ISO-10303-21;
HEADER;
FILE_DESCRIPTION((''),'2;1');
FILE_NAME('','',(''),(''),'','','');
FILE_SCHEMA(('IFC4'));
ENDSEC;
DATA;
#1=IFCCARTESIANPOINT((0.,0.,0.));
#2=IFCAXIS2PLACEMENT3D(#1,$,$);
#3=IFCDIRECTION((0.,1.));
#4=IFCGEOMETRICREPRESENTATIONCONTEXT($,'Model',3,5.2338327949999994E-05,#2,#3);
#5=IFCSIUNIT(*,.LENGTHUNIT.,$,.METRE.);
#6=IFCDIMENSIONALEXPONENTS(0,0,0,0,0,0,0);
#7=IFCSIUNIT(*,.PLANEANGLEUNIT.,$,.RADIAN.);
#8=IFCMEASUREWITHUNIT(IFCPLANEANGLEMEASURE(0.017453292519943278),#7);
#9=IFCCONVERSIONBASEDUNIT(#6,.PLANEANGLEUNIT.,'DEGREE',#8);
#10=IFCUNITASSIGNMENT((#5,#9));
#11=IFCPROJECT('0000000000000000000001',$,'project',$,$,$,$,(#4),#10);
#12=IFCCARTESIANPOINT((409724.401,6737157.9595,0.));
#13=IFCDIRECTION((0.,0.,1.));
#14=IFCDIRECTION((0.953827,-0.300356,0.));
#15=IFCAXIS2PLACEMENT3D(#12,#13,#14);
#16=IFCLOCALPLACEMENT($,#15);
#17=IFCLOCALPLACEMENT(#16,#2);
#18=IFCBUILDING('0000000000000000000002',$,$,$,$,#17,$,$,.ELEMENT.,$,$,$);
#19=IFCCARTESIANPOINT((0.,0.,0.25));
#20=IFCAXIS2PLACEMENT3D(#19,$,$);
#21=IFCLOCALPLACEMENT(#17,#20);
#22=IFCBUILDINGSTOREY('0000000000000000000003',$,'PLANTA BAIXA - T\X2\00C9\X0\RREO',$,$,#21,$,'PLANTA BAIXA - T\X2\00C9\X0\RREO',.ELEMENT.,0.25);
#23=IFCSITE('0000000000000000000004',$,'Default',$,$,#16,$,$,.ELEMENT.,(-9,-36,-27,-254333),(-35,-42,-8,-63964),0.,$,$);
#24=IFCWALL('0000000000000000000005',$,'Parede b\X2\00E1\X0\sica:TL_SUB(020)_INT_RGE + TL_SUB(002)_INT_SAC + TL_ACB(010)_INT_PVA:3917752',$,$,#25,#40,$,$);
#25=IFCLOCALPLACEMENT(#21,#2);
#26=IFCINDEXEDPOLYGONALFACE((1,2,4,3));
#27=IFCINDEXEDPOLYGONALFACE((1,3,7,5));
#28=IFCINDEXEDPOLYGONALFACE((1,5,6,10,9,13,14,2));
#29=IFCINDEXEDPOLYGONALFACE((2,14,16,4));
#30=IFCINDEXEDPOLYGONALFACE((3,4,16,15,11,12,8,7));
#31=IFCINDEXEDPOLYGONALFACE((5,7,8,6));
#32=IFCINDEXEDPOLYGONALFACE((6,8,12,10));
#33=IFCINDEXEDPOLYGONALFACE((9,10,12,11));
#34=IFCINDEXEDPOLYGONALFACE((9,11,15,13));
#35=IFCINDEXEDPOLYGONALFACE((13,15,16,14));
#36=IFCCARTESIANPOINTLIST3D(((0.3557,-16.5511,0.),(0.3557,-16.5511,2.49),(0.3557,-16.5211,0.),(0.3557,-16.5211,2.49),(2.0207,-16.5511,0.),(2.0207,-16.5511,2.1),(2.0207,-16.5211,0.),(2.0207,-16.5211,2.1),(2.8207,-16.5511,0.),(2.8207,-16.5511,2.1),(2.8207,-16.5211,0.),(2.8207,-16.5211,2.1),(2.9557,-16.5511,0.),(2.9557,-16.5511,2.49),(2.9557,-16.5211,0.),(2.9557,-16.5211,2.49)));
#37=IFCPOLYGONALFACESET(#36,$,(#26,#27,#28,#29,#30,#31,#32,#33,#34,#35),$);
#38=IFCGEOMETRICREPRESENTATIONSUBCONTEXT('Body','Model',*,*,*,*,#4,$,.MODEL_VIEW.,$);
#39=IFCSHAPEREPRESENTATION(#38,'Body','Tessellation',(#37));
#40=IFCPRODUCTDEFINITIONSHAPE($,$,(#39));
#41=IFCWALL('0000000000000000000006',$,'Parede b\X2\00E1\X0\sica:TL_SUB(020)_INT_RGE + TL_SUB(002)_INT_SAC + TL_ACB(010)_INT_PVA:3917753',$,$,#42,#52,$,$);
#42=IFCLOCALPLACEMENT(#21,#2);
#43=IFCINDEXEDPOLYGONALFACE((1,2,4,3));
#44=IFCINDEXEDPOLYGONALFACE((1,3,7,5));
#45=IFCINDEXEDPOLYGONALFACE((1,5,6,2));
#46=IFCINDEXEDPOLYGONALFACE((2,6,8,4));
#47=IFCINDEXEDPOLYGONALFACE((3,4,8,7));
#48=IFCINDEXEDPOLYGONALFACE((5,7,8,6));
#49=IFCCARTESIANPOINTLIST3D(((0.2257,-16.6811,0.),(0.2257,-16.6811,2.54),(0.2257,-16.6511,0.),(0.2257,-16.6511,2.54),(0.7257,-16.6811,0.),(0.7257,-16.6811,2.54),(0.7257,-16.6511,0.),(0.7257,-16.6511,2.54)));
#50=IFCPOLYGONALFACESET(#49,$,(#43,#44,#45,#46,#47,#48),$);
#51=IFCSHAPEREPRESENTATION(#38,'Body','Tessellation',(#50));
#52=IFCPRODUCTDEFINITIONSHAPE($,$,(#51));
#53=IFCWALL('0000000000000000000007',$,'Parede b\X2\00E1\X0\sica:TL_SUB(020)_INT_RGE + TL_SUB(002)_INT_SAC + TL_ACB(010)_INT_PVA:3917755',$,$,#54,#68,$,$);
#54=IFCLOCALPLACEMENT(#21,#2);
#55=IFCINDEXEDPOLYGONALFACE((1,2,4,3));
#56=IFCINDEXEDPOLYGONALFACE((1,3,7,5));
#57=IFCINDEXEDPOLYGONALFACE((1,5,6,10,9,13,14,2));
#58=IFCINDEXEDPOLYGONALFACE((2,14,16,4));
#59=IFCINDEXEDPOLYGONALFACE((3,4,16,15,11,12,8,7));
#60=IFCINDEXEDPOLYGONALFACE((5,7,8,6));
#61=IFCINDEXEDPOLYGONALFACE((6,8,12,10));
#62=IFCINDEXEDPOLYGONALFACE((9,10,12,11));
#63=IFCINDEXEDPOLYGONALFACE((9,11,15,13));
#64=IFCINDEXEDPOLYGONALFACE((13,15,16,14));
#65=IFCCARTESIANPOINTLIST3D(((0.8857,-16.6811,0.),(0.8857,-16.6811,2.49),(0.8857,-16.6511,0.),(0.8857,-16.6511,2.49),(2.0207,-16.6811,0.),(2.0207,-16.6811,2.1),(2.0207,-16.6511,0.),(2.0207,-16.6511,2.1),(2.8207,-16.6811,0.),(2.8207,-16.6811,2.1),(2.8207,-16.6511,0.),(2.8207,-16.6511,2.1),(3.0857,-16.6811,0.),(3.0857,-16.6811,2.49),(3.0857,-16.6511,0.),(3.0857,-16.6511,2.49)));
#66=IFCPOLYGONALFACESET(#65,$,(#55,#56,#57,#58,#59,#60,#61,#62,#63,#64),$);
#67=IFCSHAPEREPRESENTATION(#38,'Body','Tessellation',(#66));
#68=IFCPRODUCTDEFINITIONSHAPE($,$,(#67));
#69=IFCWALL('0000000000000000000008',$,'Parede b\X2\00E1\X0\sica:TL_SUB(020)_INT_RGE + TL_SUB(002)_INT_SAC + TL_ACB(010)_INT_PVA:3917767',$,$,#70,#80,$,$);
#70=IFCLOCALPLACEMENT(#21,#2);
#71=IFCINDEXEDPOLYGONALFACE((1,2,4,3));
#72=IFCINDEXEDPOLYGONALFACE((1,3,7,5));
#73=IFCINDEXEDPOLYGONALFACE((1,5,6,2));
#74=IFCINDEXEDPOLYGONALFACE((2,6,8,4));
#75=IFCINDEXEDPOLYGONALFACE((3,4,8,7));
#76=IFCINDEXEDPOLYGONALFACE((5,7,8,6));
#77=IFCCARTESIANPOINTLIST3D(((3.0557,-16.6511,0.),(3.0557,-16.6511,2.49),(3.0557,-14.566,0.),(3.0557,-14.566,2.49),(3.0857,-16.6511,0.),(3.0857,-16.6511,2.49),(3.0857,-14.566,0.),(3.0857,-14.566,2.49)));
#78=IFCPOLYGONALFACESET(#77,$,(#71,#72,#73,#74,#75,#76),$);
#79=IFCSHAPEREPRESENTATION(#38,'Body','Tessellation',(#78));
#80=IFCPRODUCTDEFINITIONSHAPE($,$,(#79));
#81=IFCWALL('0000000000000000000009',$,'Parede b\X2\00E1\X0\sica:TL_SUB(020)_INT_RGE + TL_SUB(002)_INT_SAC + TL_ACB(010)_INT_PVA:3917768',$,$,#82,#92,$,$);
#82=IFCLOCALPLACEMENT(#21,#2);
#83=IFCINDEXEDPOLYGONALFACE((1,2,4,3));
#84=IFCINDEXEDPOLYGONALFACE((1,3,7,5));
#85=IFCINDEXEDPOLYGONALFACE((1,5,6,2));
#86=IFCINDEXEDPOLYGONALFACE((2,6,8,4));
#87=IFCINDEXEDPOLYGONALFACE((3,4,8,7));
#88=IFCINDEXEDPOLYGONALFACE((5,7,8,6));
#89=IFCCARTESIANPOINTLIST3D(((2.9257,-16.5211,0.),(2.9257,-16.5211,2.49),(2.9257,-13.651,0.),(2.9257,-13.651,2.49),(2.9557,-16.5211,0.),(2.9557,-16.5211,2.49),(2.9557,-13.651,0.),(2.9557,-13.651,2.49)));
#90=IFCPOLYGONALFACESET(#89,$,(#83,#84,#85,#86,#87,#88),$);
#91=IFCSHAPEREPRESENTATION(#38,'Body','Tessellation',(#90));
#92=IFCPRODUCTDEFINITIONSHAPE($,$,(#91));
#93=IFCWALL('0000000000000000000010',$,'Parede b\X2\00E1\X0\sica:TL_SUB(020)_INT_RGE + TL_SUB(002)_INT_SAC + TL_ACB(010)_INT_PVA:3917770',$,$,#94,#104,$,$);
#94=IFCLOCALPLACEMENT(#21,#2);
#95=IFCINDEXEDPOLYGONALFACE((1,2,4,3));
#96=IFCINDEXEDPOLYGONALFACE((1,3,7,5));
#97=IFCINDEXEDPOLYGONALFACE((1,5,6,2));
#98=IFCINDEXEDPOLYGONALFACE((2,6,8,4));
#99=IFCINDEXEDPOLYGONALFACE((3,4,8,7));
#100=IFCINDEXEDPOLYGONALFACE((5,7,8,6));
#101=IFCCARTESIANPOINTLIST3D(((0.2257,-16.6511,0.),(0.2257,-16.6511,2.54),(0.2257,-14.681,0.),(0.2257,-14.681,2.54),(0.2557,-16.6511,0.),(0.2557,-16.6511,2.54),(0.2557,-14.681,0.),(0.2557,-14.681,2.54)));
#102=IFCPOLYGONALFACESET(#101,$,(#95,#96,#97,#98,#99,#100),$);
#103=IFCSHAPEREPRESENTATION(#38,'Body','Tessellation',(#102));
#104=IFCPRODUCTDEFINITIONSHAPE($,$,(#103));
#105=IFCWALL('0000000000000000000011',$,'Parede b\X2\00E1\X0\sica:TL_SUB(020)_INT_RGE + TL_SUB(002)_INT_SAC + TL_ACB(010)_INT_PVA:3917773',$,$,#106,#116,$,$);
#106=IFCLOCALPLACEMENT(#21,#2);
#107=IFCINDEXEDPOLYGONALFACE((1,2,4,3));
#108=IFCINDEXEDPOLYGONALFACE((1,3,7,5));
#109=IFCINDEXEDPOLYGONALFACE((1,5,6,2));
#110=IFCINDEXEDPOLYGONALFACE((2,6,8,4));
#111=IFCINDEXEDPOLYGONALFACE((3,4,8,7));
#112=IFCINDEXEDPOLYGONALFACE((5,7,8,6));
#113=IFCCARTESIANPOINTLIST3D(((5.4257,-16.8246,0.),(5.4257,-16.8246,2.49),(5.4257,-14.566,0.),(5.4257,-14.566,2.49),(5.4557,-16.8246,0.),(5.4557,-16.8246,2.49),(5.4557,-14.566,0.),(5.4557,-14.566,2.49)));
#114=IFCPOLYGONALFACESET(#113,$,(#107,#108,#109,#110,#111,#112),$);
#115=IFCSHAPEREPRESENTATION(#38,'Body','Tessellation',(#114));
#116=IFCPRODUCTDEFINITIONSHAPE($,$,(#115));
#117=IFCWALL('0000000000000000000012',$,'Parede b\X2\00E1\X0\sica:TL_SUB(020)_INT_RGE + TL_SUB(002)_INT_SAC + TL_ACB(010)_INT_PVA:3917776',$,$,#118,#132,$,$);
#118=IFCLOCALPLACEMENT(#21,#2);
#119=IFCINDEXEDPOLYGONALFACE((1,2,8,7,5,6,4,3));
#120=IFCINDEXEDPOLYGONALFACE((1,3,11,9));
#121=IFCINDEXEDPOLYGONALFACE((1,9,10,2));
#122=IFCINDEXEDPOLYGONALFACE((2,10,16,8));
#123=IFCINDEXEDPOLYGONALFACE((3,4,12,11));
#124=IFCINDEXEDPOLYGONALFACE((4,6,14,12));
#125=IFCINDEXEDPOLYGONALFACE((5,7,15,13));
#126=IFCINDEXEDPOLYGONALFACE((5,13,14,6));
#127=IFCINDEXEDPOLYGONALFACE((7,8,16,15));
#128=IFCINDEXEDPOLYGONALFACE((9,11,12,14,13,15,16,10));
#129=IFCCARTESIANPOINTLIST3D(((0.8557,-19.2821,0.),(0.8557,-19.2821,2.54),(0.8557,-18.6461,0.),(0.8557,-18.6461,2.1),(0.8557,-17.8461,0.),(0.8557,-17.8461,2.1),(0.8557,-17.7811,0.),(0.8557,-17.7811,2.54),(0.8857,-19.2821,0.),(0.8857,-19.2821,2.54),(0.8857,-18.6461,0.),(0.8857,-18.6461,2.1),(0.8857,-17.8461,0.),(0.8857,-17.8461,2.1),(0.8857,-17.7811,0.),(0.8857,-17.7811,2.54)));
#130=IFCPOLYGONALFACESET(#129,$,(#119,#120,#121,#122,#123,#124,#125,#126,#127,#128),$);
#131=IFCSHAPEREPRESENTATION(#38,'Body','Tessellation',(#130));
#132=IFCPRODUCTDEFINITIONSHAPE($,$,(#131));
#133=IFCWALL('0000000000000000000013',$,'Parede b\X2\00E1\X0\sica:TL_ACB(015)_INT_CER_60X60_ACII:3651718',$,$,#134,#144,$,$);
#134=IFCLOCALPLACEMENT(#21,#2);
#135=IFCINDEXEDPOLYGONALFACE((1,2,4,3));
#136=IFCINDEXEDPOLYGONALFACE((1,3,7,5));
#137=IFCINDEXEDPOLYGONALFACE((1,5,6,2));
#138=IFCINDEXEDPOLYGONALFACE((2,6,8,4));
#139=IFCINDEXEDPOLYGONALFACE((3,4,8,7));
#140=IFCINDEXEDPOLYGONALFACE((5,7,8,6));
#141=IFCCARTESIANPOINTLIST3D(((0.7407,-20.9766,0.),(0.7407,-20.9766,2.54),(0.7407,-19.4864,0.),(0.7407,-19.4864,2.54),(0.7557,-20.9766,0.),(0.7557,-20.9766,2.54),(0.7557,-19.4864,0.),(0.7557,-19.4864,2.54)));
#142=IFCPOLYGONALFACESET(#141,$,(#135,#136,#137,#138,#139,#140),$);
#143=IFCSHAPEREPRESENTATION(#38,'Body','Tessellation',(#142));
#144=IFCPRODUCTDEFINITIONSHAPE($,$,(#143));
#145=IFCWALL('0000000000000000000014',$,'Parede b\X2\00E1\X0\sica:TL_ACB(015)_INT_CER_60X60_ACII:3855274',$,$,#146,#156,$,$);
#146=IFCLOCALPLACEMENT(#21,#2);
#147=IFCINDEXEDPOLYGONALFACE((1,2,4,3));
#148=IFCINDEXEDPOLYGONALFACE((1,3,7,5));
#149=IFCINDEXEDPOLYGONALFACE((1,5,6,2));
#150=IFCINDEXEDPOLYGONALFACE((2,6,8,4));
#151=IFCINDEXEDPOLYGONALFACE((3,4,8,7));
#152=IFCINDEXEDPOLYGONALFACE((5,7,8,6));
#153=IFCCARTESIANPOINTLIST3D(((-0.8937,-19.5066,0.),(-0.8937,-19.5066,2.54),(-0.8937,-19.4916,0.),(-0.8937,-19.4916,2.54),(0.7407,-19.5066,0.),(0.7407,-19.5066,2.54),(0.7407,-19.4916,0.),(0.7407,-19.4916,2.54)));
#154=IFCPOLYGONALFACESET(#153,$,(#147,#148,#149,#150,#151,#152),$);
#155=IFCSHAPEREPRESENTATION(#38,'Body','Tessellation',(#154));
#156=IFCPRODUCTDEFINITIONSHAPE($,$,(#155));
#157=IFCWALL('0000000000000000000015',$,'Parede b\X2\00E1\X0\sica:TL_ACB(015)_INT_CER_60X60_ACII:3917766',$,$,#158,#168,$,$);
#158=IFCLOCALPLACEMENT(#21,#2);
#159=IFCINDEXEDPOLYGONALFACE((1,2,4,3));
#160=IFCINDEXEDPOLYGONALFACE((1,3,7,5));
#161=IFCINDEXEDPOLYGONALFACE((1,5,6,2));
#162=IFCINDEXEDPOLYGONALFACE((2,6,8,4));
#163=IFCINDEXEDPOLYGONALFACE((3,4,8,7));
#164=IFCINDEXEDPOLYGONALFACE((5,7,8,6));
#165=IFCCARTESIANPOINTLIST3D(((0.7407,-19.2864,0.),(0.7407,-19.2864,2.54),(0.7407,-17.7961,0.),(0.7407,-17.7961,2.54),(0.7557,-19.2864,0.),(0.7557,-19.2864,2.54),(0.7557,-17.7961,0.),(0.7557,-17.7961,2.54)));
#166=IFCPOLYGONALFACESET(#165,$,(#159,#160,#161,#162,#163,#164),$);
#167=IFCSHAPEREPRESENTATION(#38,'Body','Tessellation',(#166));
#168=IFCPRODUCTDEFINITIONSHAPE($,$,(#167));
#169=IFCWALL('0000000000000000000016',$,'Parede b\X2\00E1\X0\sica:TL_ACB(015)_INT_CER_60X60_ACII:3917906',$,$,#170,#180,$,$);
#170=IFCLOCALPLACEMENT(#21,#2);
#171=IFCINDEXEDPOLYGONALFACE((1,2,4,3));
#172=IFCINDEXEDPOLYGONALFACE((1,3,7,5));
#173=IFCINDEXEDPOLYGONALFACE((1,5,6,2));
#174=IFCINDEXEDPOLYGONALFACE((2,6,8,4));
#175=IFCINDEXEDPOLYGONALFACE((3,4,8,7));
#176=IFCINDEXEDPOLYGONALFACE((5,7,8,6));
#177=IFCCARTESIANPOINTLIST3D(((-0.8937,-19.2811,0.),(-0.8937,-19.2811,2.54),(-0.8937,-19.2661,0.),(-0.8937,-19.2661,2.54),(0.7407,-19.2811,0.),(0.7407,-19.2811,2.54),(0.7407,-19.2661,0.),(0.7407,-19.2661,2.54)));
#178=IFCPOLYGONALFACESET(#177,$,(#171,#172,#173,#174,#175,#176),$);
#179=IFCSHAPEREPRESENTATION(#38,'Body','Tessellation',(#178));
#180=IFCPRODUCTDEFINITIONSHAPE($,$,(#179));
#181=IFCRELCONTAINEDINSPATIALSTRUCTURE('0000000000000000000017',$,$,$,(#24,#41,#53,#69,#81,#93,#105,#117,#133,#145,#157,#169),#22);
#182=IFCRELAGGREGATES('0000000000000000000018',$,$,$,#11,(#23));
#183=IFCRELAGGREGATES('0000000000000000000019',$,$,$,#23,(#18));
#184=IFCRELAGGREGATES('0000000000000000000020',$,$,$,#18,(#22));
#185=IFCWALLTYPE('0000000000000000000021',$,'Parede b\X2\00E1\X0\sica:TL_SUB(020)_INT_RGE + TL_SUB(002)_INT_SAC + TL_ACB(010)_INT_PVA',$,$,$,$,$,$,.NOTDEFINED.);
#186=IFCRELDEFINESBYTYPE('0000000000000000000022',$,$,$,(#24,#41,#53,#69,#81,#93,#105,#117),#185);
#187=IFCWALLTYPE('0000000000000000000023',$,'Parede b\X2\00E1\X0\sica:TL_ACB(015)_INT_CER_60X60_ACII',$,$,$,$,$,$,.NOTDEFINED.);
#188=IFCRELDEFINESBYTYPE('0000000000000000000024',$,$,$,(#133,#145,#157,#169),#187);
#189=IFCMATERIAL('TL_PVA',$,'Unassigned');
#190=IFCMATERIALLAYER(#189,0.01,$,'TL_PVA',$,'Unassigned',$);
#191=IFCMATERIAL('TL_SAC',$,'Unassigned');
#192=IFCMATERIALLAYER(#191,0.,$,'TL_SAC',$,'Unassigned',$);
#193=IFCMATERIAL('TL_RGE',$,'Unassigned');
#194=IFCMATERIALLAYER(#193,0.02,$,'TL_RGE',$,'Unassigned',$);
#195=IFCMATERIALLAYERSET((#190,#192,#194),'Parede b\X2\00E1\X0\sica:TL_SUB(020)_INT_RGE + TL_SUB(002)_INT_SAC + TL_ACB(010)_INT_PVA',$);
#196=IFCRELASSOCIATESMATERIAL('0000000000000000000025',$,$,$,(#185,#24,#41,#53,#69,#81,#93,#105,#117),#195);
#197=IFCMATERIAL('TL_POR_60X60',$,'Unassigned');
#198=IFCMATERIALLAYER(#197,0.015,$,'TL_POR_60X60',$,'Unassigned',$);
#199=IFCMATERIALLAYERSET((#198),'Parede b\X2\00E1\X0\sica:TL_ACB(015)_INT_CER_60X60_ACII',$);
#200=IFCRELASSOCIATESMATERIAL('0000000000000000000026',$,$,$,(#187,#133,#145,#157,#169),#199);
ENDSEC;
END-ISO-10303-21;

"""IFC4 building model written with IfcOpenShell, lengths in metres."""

from ifc_helpers import new_model, entity, si_unit, converted_unit, direction, frame, frame_2d, origin, place, context, subcontext, project, spatial, rectangle, extrude, material, layer, layer_set, layer_usage, type_object, element, save


model = new_model("IFC4")

# Units and contexts
model_context = context("Model", 3, precision=5.2338327949999994e-05, world=origin(), true_north=direction((0.0, 1.0)))
body_context = subcontext(model_context, "Body", "Model", "MODEL_VIEW")
ifc_project = project(units=[si_unit("LENGTHUNIT", "METRE"), converted_unit("PLANEANGLEUNIT", "DEGREE", entity("IfcPlaneAngleMeasure", 0.017453292519943278), si_unit("PLANEANGLEUNIT", "RADIAN"), dimensions=[0, 0, 0, 0, 0, 0, 0])], contexts=[model_context])

# Site, building, storey
site_placement = place(None, frame((409724.401, 6737157.9595, 0.0), z_axis=(0.0, 0.0, 1.0), x_axis=(0.953827, -0.300356, 0.0)))
site = spatial("IfcSite", under=ifc_project, at=site_placement, Name="Default", CompositionType="ELEMENT", RefLatitude=(-9, -36, -27, -254333), RefLongitude=(-35, -42, -8, -63964), RefElevation=0.0)
building_placement = place(site_placement, origin())
building = spatial("IfcBuilding", under=site, at=building_placement, CompositionType="ELEMENT")
storey_placement = place(building_placement, frame((0.0, 0.0, 0.25)))
storey = spatial("IfcBuildingStorey", under=building, at=storey_placement, Name="PLANTA BAIXA - TÉRREO", LongName="PLANTA BAIXA - TÉRREO", CompositionType="ELEMENT", Elevation=0.25)

# Wall, opening
ifc_material_1 = material(Name="TL_PVA", Category="Unassigned")
ifc_layer_1 = layer(ifc_material_1, 0.01, Name="TL_PVA", Category="Unassigned")
ifc_material_2 = material(Name="TL_SAC", Category="Unassigned")
ifc_layer_2 = layer(ifc_material_2, 0.0, Name="TL_SAC", Category="Unassigned")
ifc_material_3 = material(Name="TL_RGE", Category="Unassigned")
ifc_layer_3 = layer(ifc_material_3, 0.02, Name="TL_RGE", Category="Unassigned")
ifc_layer_set_1 = layer_set([ifc_layer_1, ifc_layer_2, ifc_layer_3], Name="Parede básica:TL_SUB(020)_INT_RGE + TL_SUB(002)_INT_SAC + TL_ACB(010)_INT_PVA")
wall_type_1 = type_object("IfcWallType", Name="Parede básica:TL_SUB(020)_INT_RGE + TL_SUB(002)_INT_SAC + TL_ACB(010)_INT_PVA", PredefinedType="NOTDEFINED", material=ifc_layer_set_1)
ifc_layer_usage_1 = layer_usage(ifc_layer_set_1, "AXIS2", "POSITIVE", -0.015)
wall_1_placement = place(storey_placement, frame((2.9557, -16.5361, 0.0), z_axis=(0.0, 0.0, 1.0), x_axis=(-1.0, 0.0, 0.0)))
wall_1 = element("IfcWall", 1, at=wall_1_placement, inside=storey, type_object=wall_type_1, material=ifc_layer_usage_1, Name="Parede básica:TL_SUB(020)_INT_RGE + TL_SUB(002)_INT_SAC + TL_ACB(010)_INT_PVA:3917752", context=body_context, shape_type="SweptSolid", body=[
    extrude(rectangle(XDim=2.6, YDim=0.03, at=frame_2d((1.3, 0.0), x_axis=(-1.0, 0.0))), origin(), (0.0, 0.0, 1.0), 2.49),
])
opening_1_placement = place(wall_1_placement, frame((2.9557, -16.5361, 0.0)))
element("IfcOpeningElement", 2, at=opening_1_placement, cuts=wall_1, PredefinedType="OPENING", context=body_context, shape_type="SweptSolid", body=[
    extrude(rectangle(XDim=2.1, YDim=0.8, at=frame_2d((0.0, 0.0), x_axis=(1.0, 0.0))), frame((-2.4207, 15.1271, 1.05), z_axis=(0.0, 1.0, 0.0), x_axis=(0.0, 0.0, 1.0)), (0.0, 0.0, 1.0), 3.048),
])

# Wall
ifc_layer_usage_2 = layer_usage(ifc_layer_set_1, "AXIS2", "POSITIVE", -0.015)
wall_2_placement = place(storey_placement, frame((0.2257, -16.6661, 0.0)))
element("IfcWall", 3, at=wall_2_placement, inside=storey, type_object=wall_type_1, material=ifc_layer_usage_2, Name="Parede básica:TL_SUB(020)_INT_RGE + TL_SUB(002)_INT_SAC + TL_ACB(010)_INT_PVA:3917753", context=body_context, shape_type="SweptSolid", body=[
    extrude(rectangle(XDim=0.5, YDim=0.03, at=frame_2d((0.25, 0.0), x_axis=(-1.0, 0.0))), origin(), (0.0, 0.0, 1.0), 2.54),
])

# Wall, opening
ifc_layer_usage_3 = layer_usage(ifc_layer_set_1, "AXIS2", "POSITIVE", -0.015)
wall_3_placement = place(storey_placement, frame((0.8857, -16.6661, 0.0)))
wall_3 = element("IfcWall", 4, at=wall_3_placement, inside=storey, type_object=wall_type_1, material=ifc_layer_usage_3, Name="Parede básica:TL_SUB(020)_INT_RGE + TL_SUB(002)_INT_SAC + TL_ACB(010)_INT_PVA:3917755", context=body_context, shape_type="SweptSolid", body=[
    extrude(rectangle(XDim=2.2, YDim=0.03, at=frame_2d((1.1, 0.0), x_axis=(-1.0, 0.0))), origin(), (0.0, 0.0, 1.0), 2.49),
])
opening_2_placement = place(wall_3_placement, frame((-0.8857, 16.6661, 0.0)))
element("IfcOpeningElement", 5, at=opening_2_placement, cuts=wall_3, PredefinedType="OPENING", context=body_context, shape_type="SweptSolid", body=[
    extrude(rectangle(XDim=2.1, YDim=0.8, at=frame_2d((0.0, 0.0), x_axis=(0.0, 1.0))), frame((2.4207, -18.1751, 1.05), z_axis=(0.0, 1.0, 0.0), x_axis=(-1.0, 0.0, 0.0)), (0.0, 0.0, 1.0), 3.048),
])

# Walls
ifc_layer_usage_4 = layer_usage(ifc_layer_set_1, "AXIS2", "NEGATIVE", 0.015)
wall_4_placement = place(storey_placement, frame((3.0707, -14.566, 0.0), z_axis=(0.0, 0.0, 1.0), x_axis=(0.0, -1.0, 0.0)))
element("IfcWall", 6, at=wall_4_placement, inside=storey, type_object=wall_type_1, material=ifc_layer_usage_4, Name="Parede básica:TL_SUB(020)_INT_RGE + TL_SUB(002)_INT_SAC + TL_ACB(010)_INT_PVA:3917767", context=body_context, shape_type="SweptSolid", body=[
    extrude(rectangle(XDim=2.0851, YDim=0.03, at=frame_2d((1.0426, 0.0), x_axis=(-1.0, 0.0))), origin(), (0.0, 0.0, 1.0), 2.49),
])
ifc_layer_usage_5 = layer_usage(ifc_layer_set_1, "AXIS2", "NEGATIVE", 0.015)
wall_5_placement = place(storey_placement, frame((2.9407, -16.5211, 0.0), z_axis=(0.0, 0.0, 1.0), x_axis=(0.0, 1.0, 0.0)))
element("IfcWall", 7, at=wall_5_placement, inside=storey, type_object=wall_type_1, material=ifc_layer_usage_5, Name="Parede básica:TL_SUB(020)_INT_RGE + TL_SUB(002)_INT_SAC + TL_ACB(010)_INT_PVA:3917768", context=body_context, shape_type="SweptSolid", body=[
    extrude(rectangle(XDim=2.8701, YDim=0.03, at=frame_2d((1.4351, 0.0), x_axis=(-1.0, 0.0))), origin(), (0.0, 0.0, 1.0), 2.49),
])
ifc_layer_usage_6 = layer_usage(ifc_layer_set_1, "AXIS2", "NEGATIVE", 0.015)
wall_6_placement = place(storey_placement, frame((0.2407, -16.6511, 0.0), z_axis=(0.0, 0.0, 1.0), x_axis=(0.0, 1.0, 0.0)))
element("IfcWall", 8, at=wall_6_placement, inside=storey, type_object=wall_type_1, material=ifc_layer_usage_6, Name="Parede básica:TL_SUB(020)_INT_RGE + TL_SUB(002)_INT_SAC + TL_ACB(010)_INT_PVA:3917770", context=body_context, shape_type="SweptSolid", body=[
    extrude(rectangle(XDim=1.9701, YDim=0.03, at=frame_2d((0.9851, 0.0), x_axis=(-1.0, 0.0))), origin(), (0.0, 0.0, 1.0), 2.54),
])
ifc_layer_usage_7 = layer_usage(ifc_layer_set_1, "AXIS2", "NEGATIVE", 0.015)
wall_7_placement = place(storey_placement, frame((5.4407, -16.8246, 0.0), z_axis=(0.0, 0.0, 1.0), x_axis=(0.0, 1.0, 0.0)))
element("IfcWall", 9, at=wall_7_placement, inside=storey, type_object=wall_type_1, material=ifc_layer_usage_7, Name="Parede básica:TL_SUB(020)_INT_RGE + TL_SUB(002)_INT_SAC + TL_ACB(010)_INT_PVA:3917773", context=body_context, shape_type="SweptSolid", body=[
    extrude(rectangle(XDim=2.2587, YDim=0.03, at=frame_2d((1.1293, 0.0), x_axis=(-1.0, 0.0))), origin(), (0.0, 0.0, 1.0), 2.49),
])

# Wall, opening
ifc_layer_usage_8 = layer_usage(ifc_layer_set_1, "AXIS2", "NEGATIVE", 0.015)
wall_8_placement = place(storey_placement, frame((0.8707, -17.7811, 0.0), z_axis=(0.0, 0.0, 1.0), x_axis=(0.0, -1.0, 0.0)))
wall_8 = element("IfcWall", 10, at=wall_8_placement, inside=storey, type_object=wall_type_1, material=ifc_layer_usage_8, Name="Parede básica:TL_SUB(020)_INT_RGE + TL_SUB(002)_INT_SAC + TL_ACB(010)_INT_PVA:3917776", context=body_context, shape_type="SweptSolid", body=[
    extrude(rectangle(XDim=1.501, YDim=0.03, at=frame_2d((0.7505, 0.0), x_axis=(-1.0, 0.0))), origin(), (0.0, 0.0, 1.0), 2.54),
])
opening_3_placement = place(wall_8_placement, frame((0.865, 0.015, 0.0)))
element("IfcOpeningElement", 11, at=opening_3_placement, cuts=wall_8, PredefinedType="OPENING", context=body_context, shape_type="SweptSolid", body=[
    extrude(rectangle(XDim=2.1, YDim=0.8, at=frame_2d((1.05, 0.4), x_axis=(1.0, 0.0))), frame((0.0, 0.0, 0.0), z_axis=(0.0, -1.0, 0.0), x_axis=(0.0, 0.0, 1.0)), (0.0, 0.0, 1.0), 0.03),
])

# Walls
ifc_material_4 = material(Name="TL_POR_60X60", Category="Unassigned")
ifc_layer_4 = layer(ifc_material_4, 0.015, Name="TL_POR_60X60", Category="Unassigned")
ifc_layer_set_2 = layer_set([ifc_layer_4], Name="Parede básica:TL_ACB(015)_INT_CER_60X60_ACII")
ifc_layer_usage_9 = layer_usage(ifc_layer_set_2, "AXIS2", "POSITIVE", -0.0075)
wall_type_2 = type_object("IfcWallType", Name="Parede básica:TL_ACB(015)_INT_CER_60X60_ACII", PredefinedType="NOTDEFINED", material=ifc_layer_set_2)
wall_9_placement = place(storey_placement, frame((0.7482, -19.4864, 0.0), z_axis=(0.0, 0.0, 1.0), x_axis=(0.0, -1.0, 0.0)))
element("IfcWall", 12, at=wall_9_placement, inside=storey, type_object=wall_type_2, material=ifc_layer_usage_9, Name="Parede básica:TL_ACB(015)_INT_CER_60X60_ACII:3651718", context=body_context, shape_type="SweptSolid", body=[
    extrude(rectangle(XDim=1.4902, YDim=0.015, at=frame_2d((0.7451, 0.0), x_axis=(-1.0, 0.0))), origin(), (0.0, 0.0, 1.0), 2.54),
])
ifc_layer_usage_10 = layer_usage(ifc_layer_set_2, "AXIS2", "NEGATIVE", 0.0075)
wall_10_placement = place(storey_placement, frame((0.7407, -19.4991, 0.0), z_axis=(0.0, 0.0, 1.0), x_axis=(-1.0, 0.0, 0.0)))
element("IfcWall", 13, at=wall_10_placement, inside=storey, type_object=wall_type_2, material=ifc_layer_usage_10, Name="Parede básica:TL_ACB(015)_INT_CER_60X60_ACII:3855274", context=body_context, shape_type="SweptSolid", body=[
    extrude(rectangle(XDim=1.6345, YDim=0.015, at=frame_2d((0.8172, 0.0), x_axis=(-1.0, 0.0))), origin(), (0.0, 0.0, 1.0), 2.54),
])
ifc_layer_usage_11 = layer_usage(ifc_layer_set_2, "AXIS2", "NEGATIVE", 0.0075)
wall_11_placement = place(storey_placement, frame((0.7482, -19.2864, 0.0), z_axis=(0.0, 0.0, 1.0), x_axis=(0.0, 1.0, 0.0)))
element("IfcWall", 14, at=wall_11_placement, inside=storey, type_object=wall_type_2, material=ifc_layer_usage_11, Name="Parede básica:TL_ACB(015)_INT_CER_60X60_ACII:3917766", context=body_context, shape_type="SweptSolid", body=[
    extrude(rectangle(XDim=1.4902, YDim=0.015, at=frame_2d((0.7451, 0.0), x_axis=(-1.0, 0.0))), origin(), (0.0, 0.0, 1.0), 2.54),
])
ifc_layer_usage_12 = layer_usage(ifc_layer_set_2, "AXIS2", "POSITIVE", -0.0075)
wall_12_placement = place(storey_placement, frame((0.7407, -19.2736, 0.0), z_axis=(0.0, 0.0, 1.0), x_axis=(-1.0, 0.0, 0.0)))
element("IfcWall", 15, at=wall_12_placement, inside=storey, type_object=wall_type_2, material=ifc_layer_usage_12, Name="Parede básica:TL_ACB(015)_INT_CER_60X60_ACII:3917906", context=body_context, shape_type="SweptSolid", body=[
    extrude(rectangle(XDim=1.6345, YDim=0.015, at=frame_2d((0.8172, 0.0), x_axis=(-1.0, 0.0))), origin(), (0.0, 0.0, 1.0), 2.54),
])

save(model, "model.ifc")
